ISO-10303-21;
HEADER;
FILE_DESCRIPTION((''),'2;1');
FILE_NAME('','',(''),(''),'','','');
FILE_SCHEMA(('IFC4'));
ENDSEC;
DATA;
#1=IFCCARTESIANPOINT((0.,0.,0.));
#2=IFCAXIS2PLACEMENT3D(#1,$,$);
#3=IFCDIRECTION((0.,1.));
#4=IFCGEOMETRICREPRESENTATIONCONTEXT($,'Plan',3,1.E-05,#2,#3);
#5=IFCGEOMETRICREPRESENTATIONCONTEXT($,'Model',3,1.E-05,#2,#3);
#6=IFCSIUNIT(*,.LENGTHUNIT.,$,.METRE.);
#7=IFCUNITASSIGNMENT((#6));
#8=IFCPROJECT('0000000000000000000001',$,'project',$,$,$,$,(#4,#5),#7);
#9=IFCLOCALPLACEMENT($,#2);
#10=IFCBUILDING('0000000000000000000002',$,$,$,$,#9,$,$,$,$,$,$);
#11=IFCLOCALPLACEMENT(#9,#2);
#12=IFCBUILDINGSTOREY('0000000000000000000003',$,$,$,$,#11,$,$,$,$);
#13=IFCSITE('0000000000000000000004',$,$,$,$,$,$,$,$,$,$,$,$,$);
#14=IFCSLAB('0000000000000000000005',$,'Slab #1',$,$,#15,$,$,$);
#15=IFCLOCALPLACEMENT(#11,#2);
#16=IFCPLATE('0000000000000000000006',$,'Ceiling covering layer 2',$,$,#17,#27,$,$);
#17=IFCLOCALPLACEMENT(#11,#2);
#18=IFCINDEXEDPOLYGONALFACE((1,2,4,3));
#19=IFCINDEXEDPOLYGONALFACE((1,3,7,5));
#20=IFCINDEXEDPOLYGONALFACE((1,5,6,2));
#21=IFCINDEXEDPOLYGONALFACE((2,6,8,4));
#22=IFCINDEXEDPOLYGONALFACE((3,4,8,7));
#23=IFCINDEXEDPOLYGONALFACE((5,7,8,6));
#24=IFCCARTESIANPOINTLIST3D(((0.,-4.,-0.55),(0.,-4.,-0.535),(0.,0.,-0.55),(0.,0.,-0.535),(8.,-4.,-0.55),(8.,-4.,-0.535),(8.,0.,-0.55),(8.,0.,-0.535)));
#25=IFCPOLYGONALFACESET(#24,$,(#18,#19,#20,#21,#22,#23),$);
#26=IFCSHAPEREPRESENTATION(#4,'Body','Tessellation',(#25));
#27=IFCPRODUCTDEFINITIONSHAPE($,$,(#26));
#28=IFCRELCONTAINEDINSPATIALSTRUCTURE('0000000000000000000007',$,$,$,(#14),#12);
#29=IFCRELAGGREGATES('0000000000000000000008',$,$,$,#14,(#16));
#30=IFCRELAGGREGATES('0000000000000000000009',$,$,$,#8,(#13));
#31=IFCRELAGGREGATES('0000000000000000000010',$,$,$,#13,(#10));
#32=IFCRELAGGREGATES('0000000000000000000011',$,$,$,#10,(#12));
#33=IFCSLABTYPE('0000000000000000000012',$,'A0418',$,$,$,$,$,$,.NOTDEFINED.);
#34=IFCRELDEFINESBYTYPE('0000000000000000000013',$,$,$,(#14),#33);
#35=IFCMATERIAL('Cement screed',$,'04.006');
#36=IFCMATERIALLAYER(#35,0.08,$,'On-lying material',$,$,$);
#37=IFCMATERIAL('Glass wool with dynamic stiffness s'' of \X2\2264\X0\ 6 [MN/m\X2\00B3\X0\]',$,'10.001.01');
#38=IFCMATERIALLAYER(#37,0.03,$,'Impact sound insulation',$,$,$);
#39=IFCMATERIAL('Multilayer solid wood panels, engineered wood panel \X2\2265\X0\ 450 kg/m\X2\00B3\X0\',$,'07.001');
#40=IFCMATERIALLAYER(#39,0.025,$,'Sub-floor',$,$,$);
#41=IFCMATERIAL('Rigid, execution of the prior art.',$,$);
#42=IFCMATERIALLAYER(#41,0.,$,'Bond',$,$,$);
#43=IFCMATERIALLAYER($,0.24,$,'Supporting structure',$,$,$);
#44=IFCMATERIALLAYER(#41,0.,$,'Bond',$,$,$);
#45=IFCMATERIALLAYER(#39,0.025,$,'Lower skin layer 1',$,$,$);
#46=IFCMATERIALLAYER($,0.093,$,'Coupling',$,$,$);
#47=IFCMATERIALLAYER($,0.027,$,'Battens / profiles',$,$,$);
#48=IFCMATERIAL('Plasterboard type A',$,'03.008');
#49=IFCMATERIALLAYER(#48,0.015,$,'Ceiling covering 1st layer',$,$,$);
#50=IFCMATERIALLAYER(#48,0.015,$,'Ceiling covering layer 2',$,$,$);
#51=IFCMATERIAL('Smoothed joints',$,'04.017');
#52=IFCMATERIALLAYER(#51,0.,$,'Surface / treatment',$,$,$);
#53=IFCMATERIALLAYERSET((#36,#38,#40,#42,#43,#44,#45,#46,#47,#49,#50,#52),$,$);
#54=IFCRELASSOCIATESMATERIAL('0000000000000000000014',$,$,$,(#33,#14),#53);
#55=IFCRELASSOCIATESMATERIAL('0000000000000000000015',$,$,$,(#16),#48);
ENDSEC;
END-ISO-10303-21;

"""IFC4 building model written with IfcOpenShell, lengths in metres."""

from ifc_helpers import new_model, si_unit, direction, frame, frame_2d, origin, place, context, project, spatial, rectangle, extrude, material, layer, layer_set, type_object, element, aggregate, save


model = new_model("IFC4")

# Units and contexts
plan_context = context("Plan", 3, precision=1e-05, world=origin(), true_north=direction((0.0, 1.0)))
model_context = context("Model", 3, precision=1e-05, world=origin(), true_north=direction((0.0, 1.0)))
ifc_project = project(units=[si_unit("LENGTHUNIT", "METRE")], contexts=[plan_context, model_context])

# Site, building, storey
site = spatial("IfcSite", under=ifc_project)
building_placement = place(None, origin())
building = spatial("IfcBuilding", under=site, at=building_placement)
storey_placement = place(building_placement, origin())
storey = spatial("IfcBuildingStorey", under=building, at=storey_placement)

# Slab, plate
ifc_material_1 = material(Name="Cement screed", Category="04.006")
ifc_layer_1 = layer(ifc_material_1, 0.08, Name="On-lying material")
ifc_material_2 = material(Name="Glass wool with dynamic stiffness s' of ≤ 6 [MN/m³]", Category="10.001.01")
ifc_layer_2 = layer(ifc_material_2, 0.03, Name="Impact sound insulation")
ifc_material_3 = material(Name="Multilayer solid wood panels, engineered wood panel ≥ 450 kg/m³", Category="07.001")
ifc_layer_3 = layer(ifc_material_3, 0.025, Name="Sub-floor")
ifc_material_4 = material(Name="Rigid, execution of the prior art.")
ifc_layer_4 = layer(ifc_material_4, 0.0, Name="Bond")
ifc_layer_5 = layer(None, 0.24, Name="Supporting structure")
ifc_layer_6 = layer(ifc_material_4, 0.0, Name="Bond")
ifc_layer_7 = layer(ifc_material_3, 0.025, Name="Lower skin layer 1")
ifc_layer_8 = layer(None, 0.093, Name="Coupling")
ifc_layer_9 = layer(None, 0.027, Name="Battens / profiles")
ifc_material_5 = material(Name="Plasterboard type A", Category="03.008")
ifc_layer_10 = layer(ifc_material_5, 0.015, Name="Ceiling covering 1st layer")
ifc_layer_11 = layer(ifc_material_5, 0.015, Name="Ceiling covering layer 2")
ifc_material_6 = material(Name="Smoothed joints", Category="04.017")
ifc_layer_12 = layer(ifc_material_6, 0.0, Name="Surface / treatment")
ifc_layer_set = layer_set([ifc_layer_1, ifc_layer_2, ifc_layer_3, ifc_layer_4, ifc_layer_5, ifc_layer_6, ifc_layer_7, ifc_layer_8, ifc_layer_9, ifc_layer_10, ifc_layer_11, ifc_layer_12])
slab_type = type_object("IfcSlabType", Name="A0418", PredefinedType="NOTDEFINED", material=ifc_layer_set)
slab_placement = place(None, frame((0.0, 0.0, 0.0), z_axis=(0.0, 0.0, -1.0), x_axis=(1.0, 0.0, 0.0)))
slab = element("IfcSlab", 1, at=slab_placement, inside=storey, type_object=slab_type, material=ifc_layer_set, Name="Slab #1")
plate_1_placement = place(slab_placement, origin())
plate_1 = element("IfcPlate", 2, at=plate_1_placement, material=ifc_material_5, Name="Ceiling covering layer 2", context=plan_context, shape_type="SweptSolid", body=[
    extrude(rectangle(XDim=8.0, YDim=4.0, at=frame_2d((4.0, 2.0), x_axis=(1.0, 0.0))), frame((0.0, 0.0, 0.535), z_axis=(0.0, 0.0, 1.0), x_axis=(1.0, 0.0, 0.0)), (0.0, 0.0, 1.0), 0.015),
])
aggregate(slab, [plate_1])

save(model, "model.ifc")
